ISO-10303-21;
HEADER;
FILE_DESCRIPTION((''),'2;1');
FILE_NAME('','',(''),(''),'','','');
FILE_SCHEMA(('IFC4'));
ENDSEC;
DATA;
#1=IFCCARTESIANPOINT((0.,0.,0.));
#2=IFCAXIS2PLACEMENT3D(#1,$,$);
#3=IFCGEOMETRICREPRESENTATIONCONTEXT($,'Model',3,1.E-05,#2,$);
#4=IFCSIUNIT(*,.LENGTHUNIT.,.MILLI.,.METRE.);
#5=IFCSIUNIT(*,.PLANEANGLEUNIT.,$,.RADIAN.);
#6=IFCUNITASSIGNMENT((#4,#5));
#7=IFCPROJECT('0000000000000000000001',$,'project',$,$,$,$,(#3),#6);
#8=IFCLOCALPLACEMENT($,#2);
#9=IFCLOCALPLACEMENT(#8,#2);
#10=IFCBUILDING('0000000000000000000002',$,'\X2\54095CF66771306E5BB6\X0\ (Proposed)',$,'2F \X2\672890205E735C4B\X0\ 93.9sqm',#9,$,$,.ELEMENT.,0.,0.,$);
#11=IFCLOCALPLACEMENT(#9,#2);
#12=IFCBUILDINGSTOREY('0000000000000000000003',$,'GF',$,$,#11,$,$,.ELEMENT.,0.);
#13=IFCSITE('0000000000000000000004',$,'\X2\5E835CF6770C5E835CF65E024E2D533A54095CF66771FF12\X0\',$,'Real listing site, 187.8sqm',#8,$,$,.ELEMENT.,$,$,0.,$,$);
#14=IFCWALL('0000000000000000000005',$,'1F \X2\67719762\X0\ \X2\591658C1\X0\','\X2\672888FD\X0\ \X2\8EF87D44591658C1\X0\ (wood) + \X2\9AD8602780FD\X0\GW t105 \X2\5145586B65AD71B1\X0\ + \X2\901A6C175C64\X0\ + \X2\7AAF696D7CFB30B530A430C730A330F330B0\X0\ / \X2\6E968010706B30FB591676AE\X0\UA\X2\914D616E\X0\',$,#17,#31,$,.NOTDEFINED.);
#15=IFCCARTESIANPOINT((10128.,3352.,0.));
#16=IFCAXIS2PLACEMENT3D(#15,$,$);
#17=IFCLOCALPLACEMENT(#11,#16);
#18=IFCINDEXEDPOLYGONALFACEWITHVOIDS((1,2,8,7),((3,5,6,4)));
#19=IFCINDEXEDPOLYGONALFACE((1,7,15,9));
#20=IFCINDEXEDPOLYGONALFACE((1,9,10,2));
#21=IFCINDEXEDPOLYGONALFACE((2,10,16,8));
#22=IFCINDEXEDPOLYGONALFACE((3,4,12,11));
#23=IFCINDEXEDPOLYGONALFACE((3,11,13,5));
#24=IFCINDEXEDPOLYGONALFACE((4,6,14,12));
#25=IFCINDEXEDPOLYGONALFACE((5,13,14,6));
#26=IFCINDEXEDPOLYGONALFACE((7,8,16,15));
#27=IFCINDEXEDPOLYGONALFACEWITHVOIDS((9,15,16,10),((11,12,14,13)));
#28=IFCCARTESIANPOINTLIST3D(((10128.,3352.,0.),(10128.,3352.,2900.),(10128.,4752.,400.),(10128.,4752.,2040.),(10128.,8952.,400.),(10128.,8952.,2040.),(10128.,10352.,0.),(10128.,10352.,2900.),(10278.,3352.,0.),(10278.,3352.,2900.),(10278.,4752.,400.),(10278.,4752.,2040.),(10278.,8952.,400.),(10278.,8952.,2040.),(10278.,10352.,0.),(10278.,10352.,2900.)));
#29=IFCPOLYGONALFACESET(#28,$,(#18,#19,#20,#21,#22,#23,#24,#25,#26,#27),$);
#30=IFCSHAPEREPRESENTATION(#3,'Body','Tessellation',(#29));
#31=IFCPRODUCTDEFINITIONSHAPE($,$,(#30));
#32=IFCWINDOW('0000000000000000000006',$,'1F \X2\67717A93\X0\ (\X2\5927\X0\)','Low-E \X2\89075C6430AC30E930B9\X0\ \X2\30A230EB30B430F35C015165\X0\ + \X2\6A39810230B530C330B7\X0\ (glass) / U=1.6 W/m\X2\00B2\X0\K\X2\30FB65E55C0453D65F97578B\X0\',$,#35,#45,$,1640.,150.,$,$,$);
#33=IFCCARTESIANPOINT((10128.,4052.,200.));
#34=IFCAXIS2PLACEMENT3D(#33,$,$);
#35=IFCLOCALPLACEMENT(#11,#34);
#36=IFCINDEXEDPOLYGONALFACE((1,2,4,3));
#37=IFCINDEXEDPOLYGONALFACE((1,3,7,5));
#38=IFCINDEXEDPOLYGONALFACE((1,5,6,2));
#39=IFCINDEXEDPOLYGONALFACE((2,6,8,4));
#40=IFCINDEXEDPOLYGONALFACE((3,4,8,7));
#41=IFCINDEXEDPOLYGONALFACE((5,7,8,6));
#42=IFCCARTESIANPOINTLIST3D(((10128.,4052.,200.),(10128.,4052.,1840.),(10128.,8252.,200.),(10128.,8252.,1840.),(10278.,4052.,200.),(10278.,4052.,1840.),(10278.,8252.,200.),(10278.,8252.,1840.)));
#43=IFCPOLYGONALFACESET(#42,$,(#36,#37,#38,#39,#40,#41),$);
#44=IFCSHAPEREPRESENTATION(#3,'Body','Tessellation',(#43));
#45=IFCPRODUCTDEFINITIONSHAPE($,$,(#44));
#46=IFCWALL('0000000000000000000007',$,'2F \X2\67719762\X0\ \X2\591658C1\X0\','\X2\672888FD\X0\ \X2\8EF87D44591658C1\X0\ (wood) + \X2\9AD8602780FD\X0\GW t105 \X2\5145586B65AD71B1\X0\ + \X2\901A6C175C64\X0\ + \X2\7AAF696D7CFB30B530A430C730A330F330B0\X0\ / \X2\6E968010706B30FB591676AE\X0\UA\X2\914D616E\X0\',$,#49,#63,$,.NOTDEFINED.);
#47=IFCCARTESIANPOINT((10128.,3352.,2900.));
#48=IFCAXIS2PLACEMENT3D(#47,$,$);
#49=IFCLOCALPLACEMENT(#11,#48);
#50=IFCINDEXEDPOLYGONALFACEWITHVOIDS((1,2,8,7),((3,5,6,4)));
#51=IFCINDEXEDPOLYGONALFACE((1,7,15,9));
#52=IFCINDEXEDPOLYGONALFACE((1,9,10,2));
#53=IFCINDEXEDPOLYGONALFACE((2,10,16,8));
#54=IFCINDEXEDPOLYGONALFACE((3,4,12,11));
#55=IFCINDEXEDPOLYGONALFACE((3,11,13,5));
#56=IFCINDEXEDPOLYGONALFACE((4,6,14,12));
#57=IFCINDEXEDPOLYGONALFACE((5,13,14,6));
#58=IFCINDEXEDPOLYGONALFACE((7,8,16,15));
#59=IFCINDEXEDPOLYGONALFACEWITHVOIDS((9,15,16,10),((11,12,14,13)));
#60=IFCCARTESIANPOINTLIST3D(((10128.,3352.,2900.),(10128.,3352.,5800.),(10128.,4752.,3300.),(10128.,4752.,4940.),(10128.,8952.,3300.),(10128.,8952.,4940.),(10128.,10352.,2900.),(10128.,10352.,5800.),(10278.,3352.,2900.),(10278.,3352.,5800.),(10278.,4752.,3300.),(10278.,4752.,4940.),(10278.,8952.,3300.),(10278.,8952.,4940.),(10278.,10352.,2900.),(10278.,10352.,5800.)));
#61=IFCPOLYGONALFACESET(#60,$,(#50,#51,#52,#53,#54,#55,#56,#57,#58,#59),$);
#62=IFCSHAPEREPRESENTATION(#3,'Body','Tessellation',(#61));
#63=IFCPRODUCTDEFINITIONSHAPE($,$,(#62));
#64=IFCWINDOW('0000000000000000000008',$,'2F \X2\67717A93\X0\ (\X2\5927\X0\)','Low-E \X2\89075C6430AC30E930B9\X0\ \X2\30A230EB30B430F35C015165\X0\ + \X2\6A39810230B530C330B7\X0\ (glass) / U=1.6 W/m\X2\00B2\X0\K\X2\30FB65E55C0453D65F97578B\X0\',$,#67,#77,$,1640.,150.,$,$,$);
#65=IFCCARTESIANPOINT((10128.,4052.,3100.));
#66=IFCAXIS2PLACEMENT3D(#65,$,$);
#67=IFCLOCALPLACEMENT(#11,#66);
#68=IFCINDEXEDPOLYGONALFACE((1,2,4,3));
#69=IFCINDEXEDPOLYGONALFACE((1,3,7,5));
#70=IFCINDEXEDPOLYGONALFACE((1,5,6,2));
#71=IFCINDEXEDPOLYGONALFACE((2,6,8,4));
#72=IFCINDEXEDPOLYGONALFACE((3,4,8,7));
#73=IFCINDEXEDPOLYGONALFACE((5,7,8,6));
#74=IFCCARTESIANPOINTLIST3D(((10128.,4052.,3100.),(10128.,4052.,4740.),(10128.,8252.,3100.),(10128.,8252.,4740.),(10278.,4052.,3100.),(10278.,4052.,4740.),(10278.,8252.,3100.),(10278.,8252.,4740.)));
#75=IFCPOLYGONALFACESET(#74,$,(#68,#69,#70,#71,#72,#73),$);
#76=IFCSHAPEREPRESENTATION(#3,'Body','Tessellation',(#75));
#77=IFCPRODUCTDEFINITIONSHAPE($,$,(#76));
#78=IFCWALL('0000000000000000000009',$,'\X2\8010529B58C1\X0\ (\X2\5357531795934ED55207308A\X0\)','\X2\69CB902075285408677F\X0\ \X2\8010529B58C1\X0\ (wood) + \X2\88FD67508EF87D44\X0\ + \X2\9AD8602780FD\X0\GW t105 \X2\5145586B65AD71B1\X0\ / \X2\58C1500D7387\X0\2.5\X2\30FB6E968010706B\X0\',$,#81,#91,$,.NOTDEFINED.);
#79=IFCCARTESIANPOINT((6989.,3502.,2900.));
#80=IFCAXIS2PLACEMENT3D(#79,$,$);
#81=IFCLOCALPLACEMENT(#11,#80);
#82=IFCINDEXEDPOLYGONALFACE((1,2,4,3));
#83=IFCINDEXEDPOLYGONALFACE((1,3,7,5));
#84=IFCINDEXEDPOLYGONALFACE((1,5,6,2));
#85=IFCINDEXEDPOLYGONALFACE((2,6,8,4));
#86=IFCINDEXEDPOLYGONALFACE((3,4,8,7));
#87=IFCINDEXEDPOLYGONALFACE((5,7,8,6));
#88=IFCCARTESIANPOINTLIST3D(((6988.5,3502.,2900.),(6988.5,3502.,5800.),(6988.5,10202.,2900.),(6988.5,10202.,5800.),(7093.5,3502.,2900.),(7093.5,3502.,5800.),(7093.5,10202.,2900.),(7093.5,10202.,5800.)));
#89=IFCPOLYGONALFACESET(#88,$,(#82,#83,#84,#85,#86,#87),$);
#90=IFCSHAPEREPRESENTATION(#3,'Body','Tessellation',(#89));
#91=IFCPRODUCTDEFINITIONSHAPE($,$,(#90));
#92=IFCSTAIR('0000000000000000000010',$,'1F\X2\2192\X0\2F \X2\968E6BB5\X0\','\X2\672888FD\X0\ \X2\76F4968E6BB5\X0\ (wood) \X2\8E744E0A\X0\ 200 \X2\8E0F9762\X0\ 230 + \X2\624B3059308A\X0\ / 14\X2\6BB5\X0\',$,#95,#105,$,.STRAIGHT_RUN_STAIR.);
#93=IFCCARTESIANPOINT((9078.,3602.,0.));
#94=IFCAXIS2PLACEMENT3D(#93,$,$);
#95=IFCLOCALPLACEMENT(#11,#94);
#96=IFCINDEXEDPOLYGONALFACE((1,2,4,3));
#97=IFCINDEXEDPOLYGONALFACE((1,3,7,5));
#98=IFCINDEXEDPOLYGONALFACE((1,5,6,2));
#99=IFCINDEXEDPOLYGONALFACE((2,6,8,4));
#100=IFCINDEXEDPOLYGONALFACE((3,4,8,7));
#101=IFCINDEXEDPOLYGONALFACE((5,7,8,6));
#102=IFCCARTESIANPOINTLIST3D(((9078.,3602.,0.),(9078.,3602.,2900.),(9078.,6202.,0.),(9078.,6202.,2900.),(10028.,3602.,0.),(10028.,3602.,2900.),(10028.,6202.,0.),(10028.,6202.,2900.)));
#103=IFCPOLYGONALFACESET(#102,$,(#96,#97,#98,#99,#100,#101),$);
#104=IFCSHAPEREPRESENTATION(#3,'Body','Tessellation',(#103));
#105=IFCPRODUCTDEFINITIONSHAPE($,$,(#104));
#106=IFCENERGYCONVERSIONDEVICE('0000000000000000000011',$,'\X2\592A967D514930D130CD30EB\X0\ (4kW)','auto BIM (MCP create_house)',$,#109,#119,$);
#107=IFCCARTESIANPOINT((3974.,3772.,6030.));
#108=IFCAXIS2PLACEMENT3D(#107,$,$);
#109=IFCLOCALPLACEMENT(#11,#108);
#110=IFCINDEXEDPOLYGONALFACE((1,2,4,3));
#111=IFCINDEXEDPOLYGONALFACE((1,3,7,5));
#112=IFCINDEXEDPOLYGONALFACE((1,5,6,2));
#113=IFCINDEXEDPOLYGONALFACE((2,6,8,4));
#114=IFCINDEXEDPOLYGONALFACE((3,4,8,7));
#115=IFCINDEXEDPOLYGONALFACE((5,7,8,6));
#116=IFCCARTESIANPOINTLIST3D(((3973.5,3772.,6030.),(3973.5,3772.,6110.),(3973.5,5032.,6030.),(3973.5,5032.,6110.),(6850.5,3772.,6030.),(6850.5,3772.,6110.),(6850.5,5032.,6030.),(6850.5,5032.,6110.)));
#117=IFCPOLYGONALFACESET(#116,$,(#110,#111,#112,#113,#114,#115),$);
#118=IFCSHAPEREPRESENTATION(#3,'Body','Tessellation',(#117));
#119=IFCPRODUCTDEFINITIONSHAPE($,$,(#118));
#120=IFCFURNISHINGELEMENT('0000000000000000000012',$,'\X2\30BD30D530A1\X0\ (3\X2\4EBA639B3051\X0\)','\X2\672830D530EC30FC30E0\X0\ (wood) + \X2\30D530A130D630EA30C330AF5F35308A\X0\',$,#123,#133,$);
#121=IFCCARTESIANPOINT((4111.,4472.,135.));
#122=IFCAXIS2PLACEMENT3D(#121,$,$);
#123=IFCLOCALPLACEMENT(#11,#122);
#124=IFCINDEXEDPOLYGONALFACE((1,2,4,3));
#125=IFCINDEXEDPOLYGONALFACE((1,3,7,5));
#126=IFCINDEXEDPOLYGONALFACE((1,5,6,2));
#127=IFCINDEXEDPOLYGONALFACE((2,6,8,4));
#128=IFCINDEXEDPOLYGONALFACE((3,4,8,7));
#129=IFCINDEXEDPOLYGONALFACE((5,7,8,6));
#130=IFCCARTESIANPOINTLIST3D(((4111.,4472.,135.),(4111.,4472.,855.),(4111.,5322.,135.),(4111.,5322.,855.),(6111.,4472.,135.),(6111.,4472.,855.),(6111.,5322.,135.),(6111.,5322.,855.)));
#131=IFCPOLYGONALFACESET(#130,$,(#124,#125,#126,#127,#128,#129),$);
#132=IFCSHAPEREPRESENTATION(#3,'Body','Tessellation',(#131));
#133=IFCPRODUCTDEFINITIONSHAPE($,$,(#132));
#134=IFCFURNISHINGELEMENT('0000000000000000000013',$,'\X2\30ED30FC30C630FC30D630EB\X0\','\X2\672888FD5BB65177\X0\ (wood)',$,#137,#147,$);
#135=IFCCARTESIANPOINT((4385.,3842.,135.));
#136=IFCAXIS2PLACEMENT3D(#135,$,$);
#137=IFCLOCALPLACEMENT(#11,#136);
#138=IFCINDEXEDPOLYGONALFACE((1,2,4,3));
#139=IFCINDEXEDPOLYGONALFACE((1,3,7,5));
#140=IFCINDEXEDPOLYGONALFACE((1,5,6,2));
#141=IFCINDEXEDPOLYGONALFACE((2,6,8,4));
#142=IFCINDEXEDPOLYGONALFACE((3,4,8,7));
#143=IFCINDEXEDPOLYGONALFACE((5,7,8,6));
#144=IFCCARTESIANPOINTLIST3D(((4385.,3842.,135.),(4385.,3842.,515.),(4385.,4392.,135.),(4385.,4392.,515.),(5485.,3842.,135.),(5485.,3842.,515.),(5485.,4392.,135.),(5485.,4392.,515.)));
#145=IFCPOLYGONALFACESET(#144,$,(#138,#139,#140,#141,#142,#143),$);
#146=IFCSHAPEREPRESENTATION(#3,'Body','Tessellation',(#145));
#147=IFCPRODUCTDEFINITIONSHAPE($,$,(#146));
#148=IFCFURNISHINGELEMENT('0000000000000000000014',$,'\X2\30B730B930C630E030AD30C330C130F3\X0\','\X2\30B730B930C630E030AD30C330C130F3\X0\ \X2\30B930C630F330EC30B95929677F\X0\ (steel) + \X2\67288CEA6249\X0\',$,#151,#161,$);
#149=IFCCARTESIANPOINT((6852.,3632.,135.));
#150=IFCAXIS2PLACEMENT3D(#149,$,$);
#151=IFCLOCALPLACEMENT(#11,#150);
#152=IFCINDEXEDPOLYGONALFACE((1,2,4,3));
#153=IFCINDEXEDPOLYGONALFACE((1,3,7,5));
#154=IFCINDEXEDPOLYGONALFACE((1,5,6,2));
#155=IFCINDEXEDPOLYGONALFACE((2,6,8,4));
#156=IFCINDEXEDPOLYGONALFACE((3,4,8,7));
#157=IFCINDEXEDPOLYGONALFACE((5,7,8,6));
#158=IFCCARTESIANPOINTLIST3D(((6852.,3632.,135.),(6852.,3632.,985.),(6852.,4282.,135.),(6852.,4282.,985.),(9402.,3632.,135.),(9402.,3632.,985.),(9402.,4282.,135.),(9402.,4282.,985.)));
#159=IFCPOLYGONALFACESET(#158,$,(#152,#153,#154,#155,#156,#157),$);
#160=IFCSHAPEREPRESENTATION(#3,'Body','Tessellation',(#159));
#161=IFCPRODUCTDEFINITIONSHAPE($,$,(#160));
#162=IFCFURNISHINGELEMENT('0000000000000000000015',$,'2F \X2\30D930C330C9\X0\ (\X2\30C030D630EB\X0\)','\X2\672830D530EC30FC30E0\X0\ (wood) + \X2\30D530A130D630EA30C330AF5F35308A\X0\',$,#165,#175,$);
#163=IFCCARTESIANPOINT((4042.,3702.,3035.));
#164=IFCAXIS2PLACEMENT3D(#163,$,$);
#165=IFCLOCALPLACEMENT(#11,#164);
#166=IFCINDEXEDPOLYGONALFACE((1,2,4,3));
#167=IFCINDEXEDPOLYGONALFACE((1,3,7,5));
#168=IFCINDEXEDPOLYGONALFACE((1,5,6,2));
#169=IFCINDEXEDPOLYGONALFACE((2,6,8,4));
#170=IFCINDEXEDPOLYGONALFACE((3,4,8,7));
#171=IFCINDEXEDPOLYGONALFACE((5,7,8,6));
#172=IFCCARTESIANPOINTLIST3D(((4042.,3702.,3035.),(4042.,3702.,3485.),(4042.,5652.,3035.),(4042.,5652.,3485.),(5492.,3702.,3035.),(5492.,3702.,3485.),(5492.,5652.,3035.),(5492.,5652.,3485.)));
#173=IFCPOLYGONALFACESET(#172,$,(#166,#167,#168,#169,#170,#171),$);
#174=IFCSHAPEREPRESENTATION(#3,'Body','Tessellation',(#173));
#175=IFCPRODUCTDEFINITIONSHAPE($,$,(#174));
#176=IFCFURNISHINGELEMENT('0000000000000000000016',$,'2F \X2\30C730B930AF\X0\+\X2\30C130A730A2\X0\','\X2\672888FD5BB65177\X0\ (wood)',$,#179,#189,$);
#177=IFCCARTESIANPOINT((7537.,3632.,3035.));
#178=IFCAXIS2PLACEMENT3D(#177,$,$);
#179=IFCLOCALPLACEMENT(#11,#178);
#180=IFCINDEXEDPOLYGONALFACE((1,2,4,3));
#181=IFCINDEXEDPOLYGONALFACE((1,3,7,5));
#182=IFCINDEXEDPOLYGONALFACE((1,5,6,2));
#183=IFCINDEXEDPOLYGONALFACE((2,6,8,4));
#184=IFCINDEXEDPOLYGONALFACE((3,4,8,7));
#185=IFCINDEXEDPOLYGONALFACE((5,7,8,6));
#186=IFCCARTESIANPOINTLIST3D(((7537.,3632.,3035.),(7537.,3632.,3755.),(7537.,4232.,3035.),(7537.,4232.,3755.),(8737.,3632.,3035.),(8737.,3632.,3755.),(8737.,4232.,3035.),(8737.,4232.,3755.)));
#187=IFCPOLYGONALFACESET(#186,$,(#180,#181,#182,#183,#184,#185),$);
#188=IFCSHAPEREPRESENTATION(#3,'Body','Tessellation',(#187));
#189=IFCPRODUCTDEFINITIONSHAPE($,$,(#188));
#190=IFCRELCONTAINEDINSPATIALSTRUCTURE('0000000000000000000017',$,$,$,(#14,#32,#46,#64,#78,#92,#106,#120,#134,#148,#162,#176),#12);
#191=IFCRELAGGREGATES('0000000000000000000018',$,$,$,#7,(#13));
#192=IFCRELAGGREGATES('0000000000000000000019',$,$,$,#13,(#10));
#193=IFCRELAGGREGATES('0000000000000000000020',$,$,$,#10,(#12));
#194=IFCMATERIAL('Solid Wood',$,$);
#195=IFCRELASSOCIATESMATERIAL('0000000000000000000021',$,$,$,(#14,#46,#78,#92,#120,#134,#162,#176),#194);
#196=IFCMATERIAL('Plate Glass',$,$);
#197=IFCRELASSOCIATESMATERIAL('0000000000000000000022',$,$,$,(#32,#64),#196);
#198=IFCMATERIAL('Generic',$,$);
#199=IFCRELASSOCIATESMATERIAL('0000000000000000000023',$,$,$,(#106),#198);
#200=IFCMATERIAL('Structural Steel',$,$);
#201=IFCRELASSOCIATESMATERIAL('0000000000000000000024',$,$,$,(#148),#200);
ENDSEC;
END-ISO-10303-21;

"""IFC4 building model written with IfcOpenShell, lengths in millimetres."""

from ifc_helpers import new_model, si_unit, frame, frame_2d, origin, place, context, project, spatial, rectangle, extrude, material, element, fill, save


model = new_model("IFC4")

# Units and contexts
model_context = context("Model", 3, precision=1e-05, world=origin())
ifc_project = project(units=[si_unit("LENGTHUNIT", "METRE", prefix="MILLI"), si_unit("PLANEANGLEUNIT", "RADIAN")], contexts=[model_context])

# Site, building, storey
site_placement = place(None, origin())
site = spatial("IfcSite", under=ifc_project, at=site_placement, Name="広島県広島市中区吉島東２", ObjectType="Real listing site, 187.8sqm", CompositionType="ELEMENT", RefElevation=0.0)
building_placement = place(site_placement, origin())
building = spatial("IfcBuilding", under=site, at=building_placement, Name="吉島東の家 (Proposed)", ObjectType="2F 木造平屋 93.9sqm", CompositionType="ELEMENT", ElevationOfRefHeight=0.0, ElevationOfTerrain=0.0)
storey_placement = place(building_placement, origin())
storey = spatial("IfcBuildingStorey", under=building, at=storey_placement, Name="GF", CompositionType="ELEMENT", Elevation=0.0)

# Wall, opening, window
ifc_material_1 = material(Name="Solid Wood")
wall_1_placement = place(storey_placement, frame((10128.0, 3352.0, 0.0)))
wall_1 = element("IfcWall", 1, at=wall_1_placement, inside=storey, material=ifc_material_1, Name="1F 東面 外壁", Description="木製 軸組外壁 (wood) + 高性能GW t105 充填断熱 + 通気層 + 窯業系サイディング / 準耐火・外皮UA配慮", PredefinedType="NOTDEFINED", context=model_context, shape_type="SweptSolid", body=[
    extrude(rectangle(XDim=150.0, YDim=7000.0, at=frame_2d((75.0, 3500.0))), frame((10128.0, 3352.0, 0.0)), (0.0, 0.0, 1.0), 2900.0),
])
opening_1_placement = place(storey_placement, frame((10128.0, 4052.0, 200.0)))
opening_1 = element("IfcOpeningElement", 2, at=opening_1_placement, cuts=wall_1, PredefinedType="NOTDEFINED", context=model_context, shape_type="SweptSolid", body=[
    extrude(rectangle(XDim=150.0, YDim=4200.0, at=frame_2d((75.0, 2100.0))), frame((10128.0, 4052.0, 200.0)), (0.0, 0.0, 1.0), 1640.0),
])
ifc_material_2 = material(Name="Plate Glass")
window_1_placement = place(storey_placement, frame((10128.0, 4052.0, 200.0)))
window_1 = element("IfcWindow", 3, at=window_1_placement, inside=storey, material=ifc_material_2, Name="1F 東窓 (大)", Description="Low-E 複層ガラス アルゴン封入 + 樹脂サッシ (glass) / U=1.6 W/m²K・日射取得型", OverallHeight=1640.0, OverallWidth=150.0, context=model_context, shape_type="SweptSolid", body=[
    extrude(rectangle(XDim=150.0, YDim=4200.0, at=frame_2d((75.0, 2100.0))), frame((10128.0, 4052.0, 200.0)), (0.0, 0.0, 1.0), 1640.0),
])
fill(opening_1, window_1)

# Wall, opening, window
wall_2_placement = place(storey_placement, frame((10128.0, 3352.0, 2900.0)))
wall_2 = element("IfcWall", 4, at=wall_2_placement, inside=storey, material=ifc_material_1, Name="2F 東面 外壁", Description="木製 軸組外壁 (wood) + 高性能GW t105 充填断熱 + 通気層 + 窯業系サイディング / 準耐火・外皮UA配慮", PredefinedType="NOTDEFINED", context=model_context, shape_type="SweptSolid", body=[
    extrude(rectangle(XDim=150.0, YDim=7000.0, at=frame_2d((75.0, 3500.0))), frame((10128.0, 3352.0, 2900.0)), (0.0, 0.0, 1.0), 2900.0),
])
opening_2_placement = place(storey_placement, frame((10128.0, 4052.0, 3100.0)))
opening_2 = element("IfcOpeningElement", 5, at=opening_2_placement, cuts=wall_2, PredefinedType="NOTDEFINED", context=model_context, shape_type="SweptSolid", body=[
    extrude(rectangle(XDim=150.0, YDim=4200.0, at=frame_2d((75.0, 2100.0))), frame((10128.0, 4052.0, 3100.0)), (0.0, 0.0, 1.0), 1640.0),
])
window_2_placement = place(storey_placement, frame((10128.0, 4052.0, 3100.0)))
window_2 = element("IfcWindow", 6, at=window_2_placement, inside=storey, material=ifc_material_2, Name="2F 東窓 (大)", Description="Low-E 複層ガラス アルゴン封入 + 樹脂サッシ (glass) / U=1.6 W/m²K・日射取得型", OverallHeight=1640.0, OverallWidth=150.0, context=model_context, shape_type="SweptSolid", body=[
    extrude(rectangle(XDim=150.0, YDim=4200.0, at=frame_2d((75.0, 2100.0))), frame((10128.0, 4052.0, 3100.0)), (0.0, 0.0, 1.0), 1640.0),
])
fill(opening_2, window_2)

# Wall
wall_3_placement = place(storey_placement, frame((6989.0, 3502.0, 2900.0)))
element("IfcWall", 7, at=wall_3_placement, inside=storey, material=ifc_material_1, Name="耐力壁 (南北間仕切り)", Description="構造用合板 耐力壁 (wood) + 製材軸組 + 高性能GW t105 充填断熱 / 壁倍率2.5・準耐火", PredefinedType="NOTDEFINED", context=model_context, shape_type="SweptSolid", body=[
    extrude(rectangle(XDim=105.0, YDim=6700.0, at=frame_2d((52.0, 3350.0))), frame((6989.0, 3502.0, 2900.0)), (0.0, 0.0, 1.0), 2900.0),
])

# Stair
stair_placement = place(storey_placement, frame((9078.0, 3602.0, 0.0)))
element("IfcStair", 8, at=stair_placement, inside=storey, material=ifc_material_1, Name="1F→2F 階段", Description="木製 直階段 (wood) 蹴上 200 踏面 230 + 手すり / 14段", PredefinedType="STRAIGHT_RUN_STAIR", context=model_context, shape_type="SweptSolid", body=[
    extrude(rectangle(XDim=950.0, YDim=2600.0, at=frame_2d((475.0, 1300.0))), frame((9078.0, 3602.0, 0.0)), (0.0, 0.0, 1.0), 2900.0),
])

# Energy conversion device
ifc_material_3 = material(Name="Generic")
energy_conversion_device_placement = place(storey_placement, frame((3974.0, 3772.0, 6030.0)))
element("IfcEnergyConversionDevice", 9, at=energy_conversion_device_placement, inside=storey, material=ifc_material_3, Name="太陽光パネル (4kW)", Description="auto BIM (MCP create_house)", context=model_context, shape_type="SweptSolid", body=[
    extrude(rectangle(XDim=2877.0, YDim=1260.0, at=frame_2d((1438.0, 630.0))), frame((3974.0, 3772.0, 6030.0)), (0.0, 0.0, 1.0), 80.0),
])

# Furnishing elements
furnishing_1_placement = place(storey_placement, frame((4111.0, 4472.0, 135.0)))
element("IfcFurnishingElement", 10, at=furnishing_1_placement, inside=storey, material=ifc_material_1, Name="ソファ (3人掛け)", Description="木フレーム (wood) + ファブリック張り", context=model_context, shape_type="SweptSolid", body=[
    extrude(rectangle(XDim=2000.0, YDim=850.0, at=frame_2d((1000.0, 425.0))), frame((4111.0, 4472.0, 135.0)), (0.0, 0.0, 1.0), 720.0),
])
furnishing_2_placement = place(storey_placement, frame((4385.0, 3842.0, 135.0)))
element("IfcFurnishingElement", 11, at=furnishing_2_placement, inside=storey, material=ifc_material_1, Name="ローテーブル", Description="木製家具 (wood)", context=model_context, shape_type="SweptSolid", body=[
    extrude(rectangle(XDim=1100.0, YDim=550.0, at=frame_2d((550.0, 275.0))), frame((4385.0, 3842.0, 135.0)), (0.0, 0.0, 1.0), 380.0),
])
ifc_material_4 = material(Name="Structural Steel")
furnishing_3_placement = place(storey_placement, frame((6852.0, 3632.0, 135.0)))
element("IfcFurnishingElement", 12, at=furnishing_3_placement, inside=storey, material=ifc_material_4, Name="システムキッチン", Description="システムキッチン ステンレス天板 (steel) + 木質扉", context=model_context, shape_type="SweptSolid", body=[
    extrude(rectangle(XDim=2550.0, YDim=650.0, at=frame_2d((1275.0, 325.0))), frame((6852.0, 3632.0, 135.0)), (0.0, 0.0, 1.0), 850.0),
])
furnishing_4_placement = place(storey_placement, frame((4042.0, 3702.0, 3035.0)))
element("IfcFurnishingElement", 13, at=furnishing_4_placement, inside=storey, material=ifc_material_1, Name="2F ベッド (ダブル)", Description="木フレーム (wood) + ファブリック張り", context=model_context, shape_type="SweptSolid", body=[
    extrude(rectangle(XDim=1450.0, YDim=1950.0, at=frame_2d((725.0, 975.0))), frame((4042.0, 3702.0, 3035.0)), (0.0, 0.0, 1.0), 450.0),
])
furnishing_5_placement = place(storey_placement, frame((7537.0, 3632.0, 3035.0)))
element("IfcFurnishingElement", 14, at=furnishing_5_placement, inside=storey, material=ifc_material_1, Name="2F デスク+チェア", Description="木製家具 (wood)", context=model_context, shape_type="SweptSolid", body=[
    extrude(rectangle(XDim=1200.0, YDim=600.0, at=frame_2d((600.0, 300.0))), frame((7537.0, 3632.0, 3035.0)), (0.0, 0.0, 1.0), 720.0),
])

save(model, "model.ifc")
